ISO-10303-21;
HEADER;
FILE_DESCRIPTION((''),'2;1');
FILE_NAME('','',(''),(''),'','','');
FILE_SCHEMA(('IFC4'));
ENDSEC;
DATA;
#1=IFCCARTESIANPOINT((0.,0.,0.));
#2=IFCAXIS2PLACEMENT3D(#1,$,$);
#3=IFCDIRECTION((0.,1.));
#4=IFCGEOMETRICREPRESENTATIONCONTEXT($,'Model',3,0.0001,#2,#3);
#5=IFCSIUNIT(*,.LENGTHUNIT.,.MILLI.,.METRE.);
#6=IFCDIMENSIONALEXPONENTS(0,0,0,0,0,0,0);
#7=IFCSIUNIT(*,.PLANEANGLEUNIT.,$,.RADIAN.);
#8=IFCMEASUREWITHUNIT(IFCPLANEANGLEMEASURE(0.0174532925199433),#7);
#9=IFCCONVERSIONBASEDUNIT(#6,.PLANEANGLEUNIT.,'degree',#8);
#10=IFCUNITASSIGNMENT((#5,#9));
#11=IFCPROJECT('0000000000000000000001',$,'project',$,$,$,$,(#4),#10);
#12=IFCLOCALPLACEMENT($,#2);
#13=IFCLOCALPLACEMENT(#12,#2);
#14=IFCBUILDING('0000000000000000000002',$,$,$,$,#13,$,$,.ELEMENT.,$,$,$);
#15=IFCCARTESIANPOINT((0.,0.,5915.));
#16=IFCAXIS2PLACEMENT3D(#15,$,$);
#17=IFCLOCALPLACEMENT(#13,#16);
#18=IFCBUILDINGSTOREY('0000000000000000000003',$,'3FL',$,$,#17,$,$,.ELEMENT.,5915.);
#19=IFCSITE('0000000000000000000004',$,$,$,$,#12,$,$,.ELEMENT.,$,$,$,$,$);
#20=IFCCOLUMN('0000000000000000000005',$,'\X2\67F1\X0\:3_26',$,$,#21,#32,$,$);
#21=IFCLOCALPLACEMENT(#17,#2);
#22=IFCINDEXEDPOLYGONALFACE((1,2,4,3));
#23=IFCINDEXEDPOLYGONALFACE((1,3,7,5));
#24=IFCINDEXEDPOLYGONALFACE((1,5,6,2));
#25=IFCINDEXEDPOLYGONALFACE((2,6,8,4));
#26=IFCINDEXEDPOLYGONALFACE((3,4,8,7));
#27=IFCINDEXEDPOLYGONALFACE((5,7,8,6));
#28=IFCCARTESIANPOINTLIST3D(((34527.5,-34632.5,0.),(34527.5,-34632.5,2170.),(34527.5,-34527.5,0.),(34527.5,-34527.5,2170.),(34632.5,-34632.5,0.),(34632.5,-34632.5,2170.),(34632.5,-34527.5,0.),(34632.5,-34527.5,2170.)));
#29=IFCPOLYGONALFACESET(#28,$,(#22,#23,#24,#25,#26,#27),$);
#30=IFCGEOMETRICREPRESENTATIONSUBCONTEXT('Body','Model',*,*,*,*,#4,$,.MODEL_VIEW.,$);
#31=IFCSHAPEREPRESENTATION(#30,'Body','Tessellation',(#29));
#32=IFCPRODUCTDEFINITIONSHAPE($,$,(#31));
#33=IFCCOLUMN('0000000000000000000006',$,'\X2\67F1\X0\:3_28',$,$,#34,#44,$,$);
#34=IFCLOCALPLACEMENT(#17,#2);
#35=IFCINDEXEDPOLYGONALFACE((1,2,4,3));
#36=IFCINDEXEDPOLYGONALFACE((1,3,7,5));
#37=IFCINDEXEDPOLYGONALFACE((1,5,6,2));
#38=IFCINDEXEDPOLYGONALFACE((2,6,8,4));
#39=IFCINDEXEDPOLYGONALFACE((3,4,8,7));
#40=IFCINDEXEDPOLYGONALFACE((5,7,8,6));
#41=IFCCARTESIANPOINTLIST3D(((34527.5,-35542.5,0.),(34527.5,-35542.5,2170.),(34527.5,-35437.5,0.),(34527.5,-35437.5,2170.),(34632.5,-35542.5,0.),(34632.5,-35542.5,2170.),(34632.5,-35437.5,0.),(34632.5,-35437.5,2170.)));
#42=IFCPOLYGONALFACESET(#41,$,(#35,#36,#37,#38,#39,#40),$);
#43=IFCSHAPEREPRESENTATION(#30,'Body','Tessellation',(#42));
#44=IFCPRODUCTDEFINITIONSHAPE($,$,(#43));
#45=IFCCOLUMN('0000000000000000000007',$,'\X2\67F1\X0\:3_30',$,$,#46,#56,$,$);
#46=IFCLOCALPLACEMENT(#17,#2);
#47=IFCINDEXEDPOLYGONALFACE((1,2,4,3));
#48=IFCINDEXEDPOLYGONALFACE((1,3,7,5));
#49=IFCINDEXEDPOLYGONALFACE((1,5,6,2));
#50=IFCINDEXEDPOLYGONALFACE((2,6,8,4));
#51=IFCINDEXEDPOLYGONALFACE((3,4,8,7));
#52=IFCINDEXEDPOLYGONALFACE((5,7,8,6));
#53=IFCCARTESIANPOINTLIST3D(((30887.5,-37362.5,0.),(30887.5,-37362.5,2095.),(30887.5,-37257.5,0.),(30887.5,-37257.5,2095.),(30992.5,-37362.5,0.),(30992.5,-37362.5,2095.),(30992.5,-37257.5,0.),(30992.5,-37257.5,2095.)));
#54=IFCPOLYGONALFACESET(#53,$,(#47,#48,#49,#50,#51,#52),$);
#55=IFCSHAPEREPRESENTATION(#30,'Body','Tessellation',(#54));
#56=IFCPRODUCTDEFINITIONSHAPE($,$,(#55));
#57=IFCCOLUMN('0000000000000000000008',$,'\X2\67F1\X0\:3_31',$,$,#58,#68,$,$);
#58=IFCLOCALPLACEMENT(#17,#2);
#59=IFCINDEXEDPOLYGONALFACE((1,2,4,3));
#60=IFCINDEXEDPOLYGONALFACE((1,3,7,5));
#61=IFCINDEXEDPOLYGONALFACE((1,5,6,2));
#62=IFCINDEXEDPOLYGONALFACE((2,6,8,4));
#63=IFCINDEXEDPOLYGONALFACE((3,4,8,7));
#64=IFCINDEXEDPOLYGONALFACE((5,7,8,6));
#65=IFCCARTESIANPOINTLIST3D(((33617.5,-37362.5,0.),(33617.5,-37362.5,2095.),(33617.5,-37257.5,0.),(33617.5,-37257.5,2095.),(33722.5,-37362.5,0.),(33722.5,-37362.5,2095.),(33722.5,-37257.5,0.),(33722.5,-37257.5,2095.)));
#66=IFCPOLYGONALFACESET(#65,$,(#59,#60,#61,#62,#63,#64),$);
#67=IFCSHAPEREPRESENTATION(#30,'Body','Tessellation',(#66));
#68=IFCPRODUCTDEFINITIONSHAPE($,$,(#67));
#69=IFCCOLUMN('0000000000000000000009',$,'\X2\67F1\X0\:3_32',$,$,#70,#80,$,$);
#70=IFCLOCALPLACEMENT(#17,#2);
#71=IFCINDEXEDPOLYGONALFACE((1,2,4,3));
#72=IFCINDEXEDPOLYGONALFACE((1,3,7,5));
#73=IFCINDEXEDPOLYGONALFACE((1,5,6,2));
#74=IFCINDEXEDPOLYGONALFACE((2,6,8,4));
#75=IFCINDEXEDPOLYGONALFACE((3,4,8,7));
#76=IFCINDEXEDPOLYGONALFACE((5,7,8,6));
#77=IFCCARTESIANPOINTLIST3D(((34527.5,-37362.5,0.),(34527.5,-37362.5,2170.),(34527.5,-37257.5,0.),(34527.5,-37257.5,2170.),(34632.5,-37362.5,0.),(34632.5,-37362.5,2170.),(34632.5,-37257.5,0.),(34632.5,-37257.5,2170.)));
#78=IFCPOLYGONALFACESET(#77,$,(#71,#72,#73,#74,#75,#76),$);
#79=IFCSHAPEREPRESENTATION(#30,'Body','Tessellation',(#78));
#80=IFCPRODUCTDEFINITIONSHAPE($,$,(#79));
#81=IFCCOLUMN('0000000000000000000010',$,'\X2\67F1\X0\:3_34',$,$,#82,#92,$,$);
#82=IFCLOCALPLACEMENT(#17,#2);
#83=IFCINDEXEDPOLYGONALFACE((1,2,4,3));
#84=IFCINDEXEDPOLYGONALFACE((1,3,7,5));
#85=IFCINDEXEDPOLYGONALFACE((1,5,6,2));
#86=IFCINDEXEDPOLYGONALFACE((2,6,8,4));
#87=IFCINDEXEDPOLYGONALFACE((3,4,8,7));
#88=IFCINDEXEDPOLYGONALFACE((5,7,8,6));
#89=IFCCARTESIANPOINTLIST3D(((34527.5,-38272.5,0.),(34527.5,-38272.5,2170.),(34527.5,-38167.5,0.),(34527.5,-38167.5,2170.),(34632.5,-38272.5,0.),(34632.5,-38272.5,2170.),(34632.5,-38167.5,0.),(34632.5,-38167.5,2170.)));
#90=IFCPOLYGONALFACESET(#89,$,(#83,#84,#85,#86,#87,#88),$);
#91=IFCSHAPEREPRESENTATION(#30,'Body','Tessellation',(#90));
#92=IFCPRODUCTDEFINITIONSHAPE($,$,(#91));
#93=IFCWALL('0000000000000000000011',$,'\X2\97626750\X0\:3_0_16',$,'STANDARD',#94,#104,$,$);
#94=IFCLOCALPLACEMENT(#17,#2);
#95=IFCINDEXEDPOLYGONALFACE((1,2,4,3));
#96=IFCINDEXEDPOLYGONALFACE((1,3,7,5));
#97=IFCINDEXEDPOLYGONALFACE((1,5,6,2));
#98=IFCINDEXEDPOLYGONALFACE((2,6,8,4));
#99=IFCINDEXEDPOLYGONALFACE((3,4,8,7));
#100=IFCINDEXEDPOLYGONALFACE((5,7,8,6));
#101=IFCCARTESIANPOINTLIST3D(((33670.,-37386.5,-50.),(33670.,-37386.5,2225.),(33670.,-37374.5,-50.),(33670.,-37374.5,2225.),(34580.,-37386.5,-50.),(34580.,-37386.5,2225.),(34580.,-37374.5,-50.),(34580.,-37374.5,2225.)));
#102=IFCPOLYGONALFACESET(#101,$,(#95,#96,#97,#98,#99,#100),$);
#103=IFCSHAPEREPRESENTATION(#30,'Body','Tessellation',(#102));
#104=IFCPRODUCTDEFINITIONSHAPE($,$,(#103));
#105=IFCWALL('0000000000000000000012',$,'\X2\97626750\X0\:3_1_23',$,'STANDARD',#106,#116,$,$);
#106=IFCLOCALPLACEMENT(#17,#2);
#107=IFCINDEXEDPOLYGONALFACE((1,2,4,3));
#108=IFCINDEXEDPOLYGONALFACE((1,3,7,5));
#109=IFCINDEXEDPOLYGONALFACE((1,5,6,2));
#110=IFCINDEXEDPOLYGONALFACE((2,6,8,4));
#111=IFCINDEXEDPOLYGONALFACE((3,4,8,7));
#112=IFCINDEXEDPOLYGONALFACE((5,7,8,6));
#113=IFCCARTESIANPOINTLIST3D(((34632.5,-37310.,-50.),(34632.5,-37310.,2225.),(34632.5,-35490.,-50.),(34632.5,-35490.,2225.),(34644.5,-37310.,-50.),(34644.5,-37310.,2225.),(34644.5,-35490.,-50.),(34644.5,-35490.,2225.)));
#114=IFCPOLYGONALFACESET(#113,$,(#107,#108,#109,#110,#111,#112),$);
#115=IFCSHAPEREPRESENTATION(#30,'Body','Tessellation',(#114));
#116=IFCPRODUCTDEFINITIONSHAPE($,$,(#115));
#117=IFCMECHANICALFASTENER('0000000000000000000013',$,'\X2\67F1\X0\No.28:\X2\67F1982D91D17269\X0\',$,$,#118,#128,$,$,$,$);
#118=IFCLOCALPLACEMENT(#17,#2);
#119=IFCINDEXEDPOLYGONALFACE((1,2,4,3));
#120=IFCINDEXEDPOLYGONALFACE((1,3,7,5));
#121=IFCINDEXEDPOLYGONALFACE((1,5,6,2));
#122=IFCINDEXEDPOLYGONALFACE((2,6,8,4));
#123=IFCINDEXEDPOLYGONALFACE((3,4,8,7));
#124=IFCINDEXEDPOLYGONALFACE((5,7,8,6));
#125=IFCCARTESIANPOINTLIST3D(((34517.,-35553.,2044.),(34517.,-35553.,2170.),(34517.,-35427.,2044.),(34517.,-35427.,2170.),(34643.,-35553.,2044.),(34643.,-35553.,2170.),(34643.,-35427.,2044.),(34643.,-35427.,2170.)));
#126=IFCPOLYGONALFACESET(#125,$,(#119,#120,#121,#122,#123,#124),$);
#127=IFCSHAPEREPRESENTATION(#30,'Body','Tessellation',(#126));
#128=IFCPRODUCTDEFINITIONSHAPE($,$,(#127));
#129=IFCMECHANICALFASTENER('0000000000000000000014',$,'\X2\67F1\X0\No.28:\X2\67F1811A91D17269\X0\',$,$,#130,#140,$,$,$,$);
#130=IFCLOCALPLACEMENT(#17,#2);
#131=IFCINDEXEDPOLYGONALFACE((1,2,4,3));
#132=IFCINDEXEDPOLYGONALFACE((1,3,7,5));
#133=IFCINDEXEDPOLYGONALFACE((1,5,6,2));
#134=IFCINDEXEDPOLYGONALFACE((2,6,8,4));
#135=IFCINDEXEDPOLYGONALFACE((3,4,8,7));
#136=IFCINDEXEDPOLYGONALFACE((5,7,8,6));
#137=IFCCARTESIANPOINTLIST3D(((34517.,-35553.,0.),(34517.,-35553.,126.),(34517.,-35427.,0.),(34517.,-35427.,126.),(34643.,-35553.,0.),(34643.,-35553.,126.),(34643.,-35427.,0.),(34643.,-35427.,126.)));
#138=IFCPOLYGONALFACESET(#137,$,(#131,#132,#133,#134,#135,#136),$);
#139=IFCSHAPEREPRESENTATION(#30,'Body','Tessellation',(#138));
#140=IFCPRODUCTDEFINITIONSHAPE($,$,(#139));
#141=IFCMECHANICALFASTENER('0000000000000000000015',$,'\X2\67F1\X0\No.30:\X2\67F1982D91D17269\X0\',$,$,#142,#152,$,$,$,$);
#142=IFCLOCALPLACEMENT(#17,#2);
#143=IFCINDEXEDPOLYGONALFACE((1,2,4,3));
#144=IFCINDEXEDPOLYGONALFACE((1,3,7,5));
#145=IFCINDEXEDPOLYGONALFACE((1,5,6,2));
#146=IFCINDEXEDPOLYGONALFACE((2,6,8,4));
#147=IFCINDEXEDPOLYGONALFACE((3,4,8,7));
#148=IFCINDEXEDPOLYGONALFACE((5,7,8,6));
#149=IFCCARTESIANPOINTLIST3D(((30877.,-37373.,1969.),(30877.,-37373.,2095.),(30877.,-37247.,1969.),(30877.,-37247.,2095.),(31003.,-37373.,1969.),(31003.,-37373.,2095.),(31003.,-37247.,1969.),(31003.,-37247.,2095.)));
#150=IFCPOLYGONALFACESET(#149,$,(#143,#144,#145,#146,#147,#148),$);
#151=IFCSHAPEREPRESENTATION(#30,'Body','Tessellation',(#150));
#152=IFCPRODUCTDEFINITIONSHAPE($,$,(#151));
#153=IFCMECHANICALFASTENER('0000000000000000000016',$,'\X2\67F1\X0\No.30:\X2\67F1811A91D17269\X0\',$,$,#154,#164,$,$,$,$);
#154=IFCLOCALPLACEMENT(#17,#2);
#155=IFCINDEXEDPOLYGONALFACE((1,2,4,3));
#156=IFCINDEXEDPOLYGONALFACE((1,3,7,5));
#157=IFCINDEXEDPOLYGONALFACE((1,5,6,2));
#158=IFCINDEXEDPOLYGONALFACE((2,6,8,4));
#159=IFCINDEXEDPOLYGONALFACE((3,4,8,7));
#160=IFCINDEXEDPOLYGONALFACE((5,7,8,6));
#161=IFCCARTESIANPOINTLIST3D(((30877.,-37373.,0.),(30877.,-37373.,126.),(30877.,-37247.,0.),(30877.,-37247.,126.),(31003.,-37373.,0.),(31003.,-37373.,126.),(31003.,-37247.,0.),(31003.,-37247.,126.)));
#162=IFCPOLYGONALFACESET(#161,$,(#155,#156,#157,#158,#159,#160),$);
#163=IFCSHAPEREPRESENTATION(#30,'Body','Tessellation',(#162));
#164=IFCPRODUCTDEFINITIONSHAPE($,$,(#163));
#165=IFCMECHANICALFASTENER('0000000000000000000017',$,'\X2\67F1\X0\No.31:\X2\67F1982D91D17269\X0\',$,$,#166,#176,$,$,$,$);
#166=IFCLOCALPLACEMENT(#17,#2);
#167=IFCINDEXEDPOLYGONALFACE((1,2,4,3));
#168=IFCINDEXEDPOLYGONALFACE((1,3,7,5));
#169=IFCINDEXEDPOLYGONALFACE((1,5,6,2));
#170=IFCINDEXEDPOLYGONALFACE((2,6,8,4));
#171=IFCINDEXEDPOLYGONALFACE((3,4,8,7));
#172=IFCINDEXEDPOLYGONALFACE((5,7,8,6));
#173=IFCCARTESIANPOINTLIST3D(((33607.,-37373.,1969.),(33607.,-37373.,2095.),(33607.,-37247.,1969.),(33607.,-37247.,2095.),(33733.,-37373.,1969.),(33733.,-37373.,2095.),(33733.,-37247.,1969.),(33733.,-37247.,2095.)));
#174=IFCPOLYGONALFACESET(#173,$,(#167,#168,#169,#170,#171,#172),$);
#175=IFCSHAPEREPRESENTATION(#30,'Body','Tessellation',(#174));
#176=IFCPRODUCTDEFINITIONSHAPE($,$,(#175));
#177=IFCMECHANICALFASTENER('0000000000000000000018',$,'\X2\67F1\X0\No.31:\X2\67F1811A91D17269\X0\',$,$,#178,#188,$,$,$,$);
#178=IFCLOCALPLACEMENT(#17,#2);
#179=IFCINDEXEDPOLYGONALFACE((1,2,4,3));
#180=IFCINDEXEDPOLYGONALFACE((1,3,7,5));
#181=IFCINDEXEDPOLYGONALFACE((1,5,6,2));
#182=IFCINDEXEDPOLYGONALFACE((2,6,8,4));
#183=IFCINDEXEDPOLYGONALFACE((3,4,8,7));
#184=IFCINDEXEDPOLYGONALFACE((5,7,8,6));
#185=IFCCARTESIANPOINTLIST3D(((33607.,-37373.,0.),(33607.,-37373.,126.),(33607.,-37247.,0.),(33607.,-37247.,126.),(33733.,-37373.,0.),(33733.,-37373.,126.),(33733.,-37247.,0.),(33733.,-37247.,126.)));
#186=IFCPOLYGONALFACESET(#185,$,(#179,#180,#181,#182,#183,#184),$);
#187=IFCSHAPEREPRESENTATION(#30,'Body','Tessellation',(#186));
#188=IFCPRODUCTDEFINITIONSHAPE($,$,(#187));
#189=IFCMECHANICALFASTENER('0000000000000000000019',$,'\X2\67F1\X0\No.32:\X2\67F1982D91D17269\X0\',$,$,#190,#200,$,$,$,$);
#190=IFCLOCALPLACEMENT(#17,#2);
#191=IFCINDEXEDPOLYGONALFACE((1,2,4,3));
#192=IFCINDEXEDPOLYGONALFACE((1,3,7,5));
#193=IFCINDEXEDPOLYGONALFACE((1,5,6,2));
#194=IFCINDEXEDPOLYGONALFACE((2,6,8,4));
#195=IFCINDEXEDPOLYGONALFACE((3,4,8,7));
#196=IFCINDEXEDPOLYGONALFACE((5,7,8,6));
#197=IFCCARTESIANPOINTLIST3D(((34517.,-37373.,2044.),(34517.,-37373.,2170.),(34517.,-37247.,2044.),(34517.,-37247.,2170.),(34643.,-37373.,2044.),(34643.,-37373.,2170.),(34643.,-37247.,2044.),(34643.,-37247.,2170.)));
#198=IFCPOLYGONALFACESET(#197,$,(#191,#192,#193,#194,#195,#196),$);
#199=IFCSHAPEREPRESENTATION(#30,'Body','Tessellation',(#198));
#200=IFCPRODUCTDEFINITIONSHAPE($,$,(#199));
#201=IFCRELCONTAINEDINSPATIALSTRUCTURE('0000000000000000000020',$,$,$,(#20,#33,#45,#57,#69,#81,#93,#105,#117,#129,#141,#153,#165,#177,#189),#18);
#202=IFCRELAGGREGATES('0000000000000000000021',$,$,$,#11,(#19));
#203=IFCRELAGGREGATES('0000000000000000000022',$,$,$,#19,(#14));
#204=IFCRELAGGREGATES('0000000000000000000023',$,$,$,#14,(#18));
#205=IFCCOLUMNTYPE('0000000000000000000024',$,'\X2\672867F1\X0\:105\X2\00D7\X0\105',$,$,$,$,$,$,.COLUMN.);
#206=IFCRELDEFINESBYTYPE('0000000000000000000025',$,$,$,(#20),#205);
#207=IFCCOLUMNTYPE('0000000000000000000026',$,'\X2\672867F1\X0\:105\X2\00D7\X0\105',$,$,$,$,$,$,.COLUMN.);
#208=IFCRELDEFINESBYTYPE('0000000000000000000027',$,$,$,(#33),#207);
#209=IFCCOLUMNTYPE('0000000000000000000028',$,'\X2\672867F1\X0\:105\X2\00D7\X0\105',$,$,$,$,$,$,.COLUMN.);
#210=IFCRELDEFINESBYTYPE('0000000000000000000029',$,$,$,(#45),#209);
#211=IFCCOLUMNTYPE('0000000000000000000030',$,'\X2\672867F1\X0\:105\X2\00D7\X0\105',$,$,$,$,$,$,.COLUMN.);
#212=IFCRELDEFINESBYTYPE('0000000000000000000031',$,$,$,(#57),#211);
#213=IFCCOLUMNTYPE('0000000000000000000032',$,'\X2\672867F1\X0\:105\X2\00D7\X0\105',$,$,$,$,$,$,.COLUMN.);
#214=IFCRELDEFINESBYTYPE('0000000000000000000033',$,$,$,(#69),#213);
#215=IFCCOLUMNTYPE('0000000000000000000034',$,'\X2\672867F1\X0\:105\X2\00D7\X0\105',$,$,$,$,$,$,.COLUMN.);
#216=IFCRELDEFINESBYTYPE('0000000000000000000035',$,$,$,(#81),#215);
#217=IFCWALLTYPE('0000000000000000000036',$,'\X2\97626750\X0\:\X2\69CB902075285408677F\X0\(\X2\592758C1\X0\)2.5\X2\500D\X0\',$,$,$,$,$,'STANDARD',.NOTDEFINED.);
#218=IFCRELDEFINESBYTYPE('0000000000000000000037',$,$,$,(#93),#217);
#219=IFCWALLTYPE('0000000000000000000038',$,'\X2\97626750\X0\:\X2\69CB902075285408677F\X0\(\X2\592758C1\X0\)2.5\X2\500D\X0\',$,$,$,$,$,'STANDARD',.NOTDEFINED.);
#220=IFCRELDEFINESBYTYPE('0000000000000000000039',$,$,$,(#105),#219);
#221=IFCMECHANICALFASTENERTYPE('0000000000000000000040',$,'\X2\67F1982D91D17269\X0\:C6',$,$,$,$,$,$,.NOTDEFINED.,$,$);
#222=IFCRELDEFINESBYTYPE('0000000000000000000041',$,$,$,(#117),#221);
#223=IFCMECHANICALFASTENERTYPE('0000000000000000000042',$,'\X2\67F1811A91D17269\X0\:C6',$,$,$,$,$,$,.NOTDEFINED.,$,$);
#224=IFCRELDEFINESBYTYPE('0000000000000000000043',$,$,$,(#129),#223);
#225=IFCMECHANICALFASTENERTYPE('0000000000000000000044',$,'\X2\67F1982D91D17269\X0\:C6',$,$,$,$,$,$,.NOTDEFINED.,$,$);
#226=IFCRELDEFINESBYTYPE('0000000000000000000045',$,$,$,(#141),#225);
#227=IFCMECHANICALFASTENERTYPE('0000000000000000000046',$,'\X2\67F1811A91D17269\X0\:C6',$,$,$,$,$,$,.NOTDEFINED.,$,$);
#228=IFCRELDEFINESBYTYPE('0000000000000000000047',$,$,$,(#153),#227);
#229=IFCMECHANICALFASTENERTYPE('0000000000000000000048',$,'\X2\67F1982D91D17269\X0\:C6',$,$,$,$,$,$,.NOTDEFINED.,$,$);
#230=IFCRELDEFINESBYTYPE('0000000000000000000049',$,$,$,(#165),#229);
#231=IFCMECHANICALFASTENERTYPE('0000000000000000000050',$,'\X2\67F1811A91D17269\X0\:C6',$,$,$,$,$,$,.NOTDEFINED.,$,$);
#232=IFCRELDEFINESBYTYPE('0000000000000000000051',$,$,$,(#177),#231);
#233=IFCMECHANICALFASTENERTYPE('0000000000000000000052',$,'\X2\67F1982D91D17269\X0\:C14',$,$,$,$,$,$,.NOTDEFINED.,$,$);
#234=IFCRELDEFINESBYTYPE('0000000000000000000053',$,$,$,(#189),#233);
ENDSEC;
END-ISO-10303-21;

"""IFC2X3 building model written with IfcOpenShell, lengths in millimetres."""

from ifc_helpers import new_model, entity, si_unit, converted_unit, direction, frame, origin, origin_with_axes, origin_2d, place, context, subcontext, project, spatial, polyline, rectangle, outline, extrude, type_object, element, save


model = new_model("IFC2X3")

# Units and contexts
model_context = context("Model", 3, precision=0.0001, world=origin(), true_north=direction((0.0, 1.0)))
body_context = subcontext(model_context, "Body", "Model", "MODEL_VIEW")
ifc_project = project(units=[si_unit("LENGTHUNIT", "METRE", prefix="MILLI"), converted_unit("PLANEANGLEUNIT", "degree", entity("IfcPlaneAngleMeasure", 0.0174532925199433), si_unit("PLANEANGLEUNIT", "RADIAN"), dimensions=[0, 0, 0, 0, 0, 0, 0])], contexts=[model_context])

# Site, building, storey
site_placement = place(None, origin())
site = spatial("IfcSite", under=ifc_project, at=site_placement, CompositionType="ELEMENT")
building_placement = place(site_placement, origin())
building = spatial("IfcBuilding", under=site, at=building_placement, CompositionType="ELEMENT")
storey_placement = place(building_placement, frame((0.0, 0.0, 5915.0)))
storey = spatial("IfcBuildingStorey", under=building, at=storey_placement, Name="3FL", CompositionType="ELEMENT", Elevation=5915.0)

# Columns
column_type_1 = type_object("IfcColumnType", Name="木柱:105×105", PredefinedType="COLUMN")
column_1_placement = place(storey_placement, frame((34580.0, -34580.0, 0.0)))
element("IfcColumn", 1, at=column_1_placement, inside=storey, type_object=column_type_1, Name="柱:3_26", context=body_context, shape_type="SweptSolid", body=[
    extrude(rectangle(XDim=105.0, YDim=105.0, at=origin_2d()), origin_with_axes(), (0.0, 0.0, 1.0), 2170.0),
])
column_type_2 = type_object("IfcColumnType", Name="木柱:105×105", PredefinedType="COLUMN")
column_2_placement = place(storey_placement, frame((34580.0, -35490.0, 0.0)))
element("IfcColumn", 2, at=column_2_placement, inside=storey, type_object=column_type_2, Name="柱:3_28", context=body_context, shape_type="SweptSolid", body=[
    extrude(rectangle(XDim=105.0, YDim=105.0, at=origin_2d()), origin_with_axes(), (0.0, 0.0, 1.0), 2170.0),
])
column_type_3 = type_object("IfcColumnType", Name="木柱:105×105", PredefinedType="COLUMN")
column_3_placement = place(storey_placement, frame((30940.0, -37310.0, 0.0)))
element("IfcColumn", 3, at=column_3_placement, inside=storey, type_object=column_type_3, Name="柱:3_30", context=body_context, shape_type="SweptSolid", body=[
    extrude(rectangle(XDim=105.0, YDim=105.0, at=origin_2d()), origin_with_axes(), (0.0, 0.0, 1.0), 2095.0),
])
column_type_4 = type_object("IfcColumnType", Name="木柱:105×105", PredefinedType="COLUMN")
column_4_placement = place(storey_placement, frame((33670.0, -37310.0, 0.0)))
element("IfcColumn", 4, at=column_4_placement, inside=storey, type_object=column_type_4, Name="柱:3_31", context=body_context, shape_type="SweptSolid", body=[
    extrude(rectangle(XDim=105.0, YDim=105.0, at=origin_2d()), origin_with_axes(), (0.0, 0.0, 1.0), 2095.0),
])
column_type_5 = type_object("IfcColumnType", Name="木柱:105×105", PredefinedType="COLUMN")
column_5_placement = place(storey_placement, frame((34580.0, -37310.0, 0.0)))
element("IfcColumn", 5, at=column_5_placement, inside=storey, type_object=column_type_5, Name="柱:3_32", context=body_context, shape_type="SweptSolid", body=[
    extrude(rectangle(XDim=105.0, YDim=105.0, at=origin_2d()), origin_with_axes(), (0.0, 0.0, 1.0), 2170.0),
])
column_type_6 = type_object("IfcColumnType", Name="木柱:105×105", PredefinedType="COLUMN")
column_6_placement = place(storey_placement, frame((34580.0, -38220.0, 0.0)))
element("IfcColumn", 6, at=column_6_placement, inside=storey, type_object=column_type_6, Name="柱:3_34", context=body_context, shape_type="SweptSolid", body=[
    extrude(rectangle(XDim=105.0, YDim=105.0, at=origin_2d()), origin_with_axes(), (0.0, 0.0, 1.0), 2170.0),
])

# Walls
wall_type_1 = type_object("IfcWallType", Name="面材:構造用合板(大壁)2.5倍", ElementType="STANDARD", PredefinedType="NOTDEFINED")
wall_1_placement = place(storey_placement, frame((34125.0, -37374.5, -50.0), z_axis=(0.0, -1.0, 0.0), x_axis=(1.0, 0.0, 0.0)))
element("IfcWall", 7, at=wall_1_placement, inside=storey, type_object=wall_type_1, Name="面材:3_0_16", ObjectType="STANDARD", context=body_context, shape_type="SweptSolid", body=[
    extrude(outline(polyline([(455.0, 0.0, 0.0), (-455.0, 0.0, 0.0), (-455.0, 2275.0, 0.0), (455.0, 2275.0, 0.0), (455.0, 0.0, 0.0)])), origin_with_axes(), (0.0, 0.0, 1.0), 12.0),
])
wall_type_2 = type_object("IfcWallType", Name="面材:構造用合板(大壁)2.5倍", ElementType="STANDARD", PredefinedType="NOTDEFINED")
wall_2_placement = place(storey_placement, frame((34644.5, -36400.0, -50.0), z_axis=(-1.0, 0.0, 0.0), x_axis=(0.0, -1.0, 0.0)))
element("IfcWall", 8, at=wall_2_placement, inside=storey, type_object=wall_type_2, Name="面材:3_1_23", ObjectType="STANDARD", context=body_context, shape_type="SweptSolid", body=[
    extrude(outline(polyline([(910.0, 0.0, 0.0), (-910.0, 0.0, 0.0), (-910.0, 2275.0, 0.0), (910.0, 2275.0, 0.0), (910.0, 0.0, 0.0)])), origin_with_axes(), (0.0, 0.0, 1.0), 12.0),
])

# Mechanical fasteners
mechanical_fastener_type_1 = type_object("IfcMechanicalFastenerType", Name="柱頭金物:C6")
mechanical_fastener_1_placement = place(storey_placement, frame((34580.0, -35490.0, 2044.0)))
element("IfcMechanicalFastener", 9, at=mechanical_fastener_1_placement, inside=storey, type_object=mechanical_fastener_type_1, Name="柱No.28:柱頭金物", context=body_context, shape_type="SweptSolid", body=[
    extrude(rectangle(XDim=126.0, YDim=126.0, at=origin_2d()), origin_with_axes(), (0.0, 0.0, 1.0), 126.0),
])
mechanical_fastener_type_2 = type_object("IfcMechanicalFastenerType", Name="柱脚金物:C6")
mechanical_fastener_2_placement = place(storey_placement, frame((34580.0, -35490.0, 0.0)))
element("IfcMechanicalFastener", 10, at=mechanical_fastener_2_placement, inside=storey, type_object=mechanical_fastener_type_2, Name="柱No.28:柱脚金物", context=body_context, shape_type="SweptSolid", body=[
    extrude(rectangle(XDim=126.0, YDim=126.0, at=origin_2d()), origin_with_axes(), (0.0, 0.0, 1.0), 126.0),
])
mechanical_fastener_type_3 = type_object("IfcMechanicalFastenerType", Name="柱頭金物:C6")
mechanical_fastener_3_placement = place(storey_placement, frame((30940.0, -37310.0, 1969.0)))
element("IfcMechanicalFastener", 11, at=mechanical_fastener_3_placement, inside=storey, type_object=mechanical_fastener_type_3, Name="柱No.30:柱頭金物", context=body_context, shape_type="SweptSolid", body=[
    extrude(rectangle(XDim=126.0, YDim=126.0, at=origin_2d()), origin_with_axes(), (0.0, 0.0, 1.0), 126.0),
])
mechanical_fastener_type_4 = type_object("IfcMechanicalFastenerType", Name="柱脚金物:C6")
mechanical_fastener_4_placement = place(storey_placement, frame((30940.0, -37310.0, 0.0)))
element("IfcMechanicalFastener", 12, at=mechanical_fastener_4_placement, inside=storey, type_object=mechanical_fastener_type_4, Name="柱No.30:柱脚金物", context=body_context, shape_type="SweptSolid", body=[
    extrude(rectangle(XDim=126.0, YDim=126.0, at=origin_2d()), origin_with_axes(), (0.0, 0.0, 1.0), 126.0),
])
mechanical_fastener_type_5 = type_object("IfcMechanicalFastenerType", Name="柱頭金物:C6")
mechanical_fastener_5_placement = place(storey_placement, frame((33670.0, -37310.0, 1969.0)))
element("IfcMechanicalFastener", 13, at=mechanical_fastener_5_placement, inside=storey, type_object=mechanical_fastener_type_5, Name="柱No.31:柱頭金物", context=body_context, shape_type="SweptSolid", body=[
    extrude(rectangle(XDim=126.0, YDim=126.0, at=origin_2d()), origin_with_axes(), (0.0, 0.0, 1.0), 126.0),
])
mechanical_fastener_type_6 = type_object("IfcMechanicalFastenerType", Name="柱脚金物:C6")
mechanical_fastener_6_placement = place(storey_placement, frame((33670.0, -37310.0, 0.0)))
element("IfcMechanicalFastener", 14, at=mechanical_fastener_6_placement, inside=storey, type_object=mechanical_fastener_type_6, Name="柱No.31:柱脚金物", context=body_context, shape_type="SweptSolid", body=[
    extrude(rectangle(XDim=126.0, YDim=126.0, at=origin_2d()), origin_with_axes(), (0.0, 0.0, 1.0), 126.0),
])
mechanical_fastener_type_7 = type_object("IfcMechanicalFastenerType", Name="柱頭金物:C14")
mechanical_fastener_7_placement = place(storey_placement, frame((34580.0, -37310.0, 2044.0)))
element("IfcMechanicalFastener", 15, at=mechanical_fastener_7_placement, inside=storey, type_object=mechanical_fastener_type_7, Name="柱No.32:柱頭金物", context=body_context, shape_type="SweptSolid", body=[
    extrude(rectangle(XDim=126.0, YDim=126.0, at=origin_2d()), origin_with_axes(), (0.0, 0.0, 1.0), 126.0),
])

save(model, "model.ifc")
